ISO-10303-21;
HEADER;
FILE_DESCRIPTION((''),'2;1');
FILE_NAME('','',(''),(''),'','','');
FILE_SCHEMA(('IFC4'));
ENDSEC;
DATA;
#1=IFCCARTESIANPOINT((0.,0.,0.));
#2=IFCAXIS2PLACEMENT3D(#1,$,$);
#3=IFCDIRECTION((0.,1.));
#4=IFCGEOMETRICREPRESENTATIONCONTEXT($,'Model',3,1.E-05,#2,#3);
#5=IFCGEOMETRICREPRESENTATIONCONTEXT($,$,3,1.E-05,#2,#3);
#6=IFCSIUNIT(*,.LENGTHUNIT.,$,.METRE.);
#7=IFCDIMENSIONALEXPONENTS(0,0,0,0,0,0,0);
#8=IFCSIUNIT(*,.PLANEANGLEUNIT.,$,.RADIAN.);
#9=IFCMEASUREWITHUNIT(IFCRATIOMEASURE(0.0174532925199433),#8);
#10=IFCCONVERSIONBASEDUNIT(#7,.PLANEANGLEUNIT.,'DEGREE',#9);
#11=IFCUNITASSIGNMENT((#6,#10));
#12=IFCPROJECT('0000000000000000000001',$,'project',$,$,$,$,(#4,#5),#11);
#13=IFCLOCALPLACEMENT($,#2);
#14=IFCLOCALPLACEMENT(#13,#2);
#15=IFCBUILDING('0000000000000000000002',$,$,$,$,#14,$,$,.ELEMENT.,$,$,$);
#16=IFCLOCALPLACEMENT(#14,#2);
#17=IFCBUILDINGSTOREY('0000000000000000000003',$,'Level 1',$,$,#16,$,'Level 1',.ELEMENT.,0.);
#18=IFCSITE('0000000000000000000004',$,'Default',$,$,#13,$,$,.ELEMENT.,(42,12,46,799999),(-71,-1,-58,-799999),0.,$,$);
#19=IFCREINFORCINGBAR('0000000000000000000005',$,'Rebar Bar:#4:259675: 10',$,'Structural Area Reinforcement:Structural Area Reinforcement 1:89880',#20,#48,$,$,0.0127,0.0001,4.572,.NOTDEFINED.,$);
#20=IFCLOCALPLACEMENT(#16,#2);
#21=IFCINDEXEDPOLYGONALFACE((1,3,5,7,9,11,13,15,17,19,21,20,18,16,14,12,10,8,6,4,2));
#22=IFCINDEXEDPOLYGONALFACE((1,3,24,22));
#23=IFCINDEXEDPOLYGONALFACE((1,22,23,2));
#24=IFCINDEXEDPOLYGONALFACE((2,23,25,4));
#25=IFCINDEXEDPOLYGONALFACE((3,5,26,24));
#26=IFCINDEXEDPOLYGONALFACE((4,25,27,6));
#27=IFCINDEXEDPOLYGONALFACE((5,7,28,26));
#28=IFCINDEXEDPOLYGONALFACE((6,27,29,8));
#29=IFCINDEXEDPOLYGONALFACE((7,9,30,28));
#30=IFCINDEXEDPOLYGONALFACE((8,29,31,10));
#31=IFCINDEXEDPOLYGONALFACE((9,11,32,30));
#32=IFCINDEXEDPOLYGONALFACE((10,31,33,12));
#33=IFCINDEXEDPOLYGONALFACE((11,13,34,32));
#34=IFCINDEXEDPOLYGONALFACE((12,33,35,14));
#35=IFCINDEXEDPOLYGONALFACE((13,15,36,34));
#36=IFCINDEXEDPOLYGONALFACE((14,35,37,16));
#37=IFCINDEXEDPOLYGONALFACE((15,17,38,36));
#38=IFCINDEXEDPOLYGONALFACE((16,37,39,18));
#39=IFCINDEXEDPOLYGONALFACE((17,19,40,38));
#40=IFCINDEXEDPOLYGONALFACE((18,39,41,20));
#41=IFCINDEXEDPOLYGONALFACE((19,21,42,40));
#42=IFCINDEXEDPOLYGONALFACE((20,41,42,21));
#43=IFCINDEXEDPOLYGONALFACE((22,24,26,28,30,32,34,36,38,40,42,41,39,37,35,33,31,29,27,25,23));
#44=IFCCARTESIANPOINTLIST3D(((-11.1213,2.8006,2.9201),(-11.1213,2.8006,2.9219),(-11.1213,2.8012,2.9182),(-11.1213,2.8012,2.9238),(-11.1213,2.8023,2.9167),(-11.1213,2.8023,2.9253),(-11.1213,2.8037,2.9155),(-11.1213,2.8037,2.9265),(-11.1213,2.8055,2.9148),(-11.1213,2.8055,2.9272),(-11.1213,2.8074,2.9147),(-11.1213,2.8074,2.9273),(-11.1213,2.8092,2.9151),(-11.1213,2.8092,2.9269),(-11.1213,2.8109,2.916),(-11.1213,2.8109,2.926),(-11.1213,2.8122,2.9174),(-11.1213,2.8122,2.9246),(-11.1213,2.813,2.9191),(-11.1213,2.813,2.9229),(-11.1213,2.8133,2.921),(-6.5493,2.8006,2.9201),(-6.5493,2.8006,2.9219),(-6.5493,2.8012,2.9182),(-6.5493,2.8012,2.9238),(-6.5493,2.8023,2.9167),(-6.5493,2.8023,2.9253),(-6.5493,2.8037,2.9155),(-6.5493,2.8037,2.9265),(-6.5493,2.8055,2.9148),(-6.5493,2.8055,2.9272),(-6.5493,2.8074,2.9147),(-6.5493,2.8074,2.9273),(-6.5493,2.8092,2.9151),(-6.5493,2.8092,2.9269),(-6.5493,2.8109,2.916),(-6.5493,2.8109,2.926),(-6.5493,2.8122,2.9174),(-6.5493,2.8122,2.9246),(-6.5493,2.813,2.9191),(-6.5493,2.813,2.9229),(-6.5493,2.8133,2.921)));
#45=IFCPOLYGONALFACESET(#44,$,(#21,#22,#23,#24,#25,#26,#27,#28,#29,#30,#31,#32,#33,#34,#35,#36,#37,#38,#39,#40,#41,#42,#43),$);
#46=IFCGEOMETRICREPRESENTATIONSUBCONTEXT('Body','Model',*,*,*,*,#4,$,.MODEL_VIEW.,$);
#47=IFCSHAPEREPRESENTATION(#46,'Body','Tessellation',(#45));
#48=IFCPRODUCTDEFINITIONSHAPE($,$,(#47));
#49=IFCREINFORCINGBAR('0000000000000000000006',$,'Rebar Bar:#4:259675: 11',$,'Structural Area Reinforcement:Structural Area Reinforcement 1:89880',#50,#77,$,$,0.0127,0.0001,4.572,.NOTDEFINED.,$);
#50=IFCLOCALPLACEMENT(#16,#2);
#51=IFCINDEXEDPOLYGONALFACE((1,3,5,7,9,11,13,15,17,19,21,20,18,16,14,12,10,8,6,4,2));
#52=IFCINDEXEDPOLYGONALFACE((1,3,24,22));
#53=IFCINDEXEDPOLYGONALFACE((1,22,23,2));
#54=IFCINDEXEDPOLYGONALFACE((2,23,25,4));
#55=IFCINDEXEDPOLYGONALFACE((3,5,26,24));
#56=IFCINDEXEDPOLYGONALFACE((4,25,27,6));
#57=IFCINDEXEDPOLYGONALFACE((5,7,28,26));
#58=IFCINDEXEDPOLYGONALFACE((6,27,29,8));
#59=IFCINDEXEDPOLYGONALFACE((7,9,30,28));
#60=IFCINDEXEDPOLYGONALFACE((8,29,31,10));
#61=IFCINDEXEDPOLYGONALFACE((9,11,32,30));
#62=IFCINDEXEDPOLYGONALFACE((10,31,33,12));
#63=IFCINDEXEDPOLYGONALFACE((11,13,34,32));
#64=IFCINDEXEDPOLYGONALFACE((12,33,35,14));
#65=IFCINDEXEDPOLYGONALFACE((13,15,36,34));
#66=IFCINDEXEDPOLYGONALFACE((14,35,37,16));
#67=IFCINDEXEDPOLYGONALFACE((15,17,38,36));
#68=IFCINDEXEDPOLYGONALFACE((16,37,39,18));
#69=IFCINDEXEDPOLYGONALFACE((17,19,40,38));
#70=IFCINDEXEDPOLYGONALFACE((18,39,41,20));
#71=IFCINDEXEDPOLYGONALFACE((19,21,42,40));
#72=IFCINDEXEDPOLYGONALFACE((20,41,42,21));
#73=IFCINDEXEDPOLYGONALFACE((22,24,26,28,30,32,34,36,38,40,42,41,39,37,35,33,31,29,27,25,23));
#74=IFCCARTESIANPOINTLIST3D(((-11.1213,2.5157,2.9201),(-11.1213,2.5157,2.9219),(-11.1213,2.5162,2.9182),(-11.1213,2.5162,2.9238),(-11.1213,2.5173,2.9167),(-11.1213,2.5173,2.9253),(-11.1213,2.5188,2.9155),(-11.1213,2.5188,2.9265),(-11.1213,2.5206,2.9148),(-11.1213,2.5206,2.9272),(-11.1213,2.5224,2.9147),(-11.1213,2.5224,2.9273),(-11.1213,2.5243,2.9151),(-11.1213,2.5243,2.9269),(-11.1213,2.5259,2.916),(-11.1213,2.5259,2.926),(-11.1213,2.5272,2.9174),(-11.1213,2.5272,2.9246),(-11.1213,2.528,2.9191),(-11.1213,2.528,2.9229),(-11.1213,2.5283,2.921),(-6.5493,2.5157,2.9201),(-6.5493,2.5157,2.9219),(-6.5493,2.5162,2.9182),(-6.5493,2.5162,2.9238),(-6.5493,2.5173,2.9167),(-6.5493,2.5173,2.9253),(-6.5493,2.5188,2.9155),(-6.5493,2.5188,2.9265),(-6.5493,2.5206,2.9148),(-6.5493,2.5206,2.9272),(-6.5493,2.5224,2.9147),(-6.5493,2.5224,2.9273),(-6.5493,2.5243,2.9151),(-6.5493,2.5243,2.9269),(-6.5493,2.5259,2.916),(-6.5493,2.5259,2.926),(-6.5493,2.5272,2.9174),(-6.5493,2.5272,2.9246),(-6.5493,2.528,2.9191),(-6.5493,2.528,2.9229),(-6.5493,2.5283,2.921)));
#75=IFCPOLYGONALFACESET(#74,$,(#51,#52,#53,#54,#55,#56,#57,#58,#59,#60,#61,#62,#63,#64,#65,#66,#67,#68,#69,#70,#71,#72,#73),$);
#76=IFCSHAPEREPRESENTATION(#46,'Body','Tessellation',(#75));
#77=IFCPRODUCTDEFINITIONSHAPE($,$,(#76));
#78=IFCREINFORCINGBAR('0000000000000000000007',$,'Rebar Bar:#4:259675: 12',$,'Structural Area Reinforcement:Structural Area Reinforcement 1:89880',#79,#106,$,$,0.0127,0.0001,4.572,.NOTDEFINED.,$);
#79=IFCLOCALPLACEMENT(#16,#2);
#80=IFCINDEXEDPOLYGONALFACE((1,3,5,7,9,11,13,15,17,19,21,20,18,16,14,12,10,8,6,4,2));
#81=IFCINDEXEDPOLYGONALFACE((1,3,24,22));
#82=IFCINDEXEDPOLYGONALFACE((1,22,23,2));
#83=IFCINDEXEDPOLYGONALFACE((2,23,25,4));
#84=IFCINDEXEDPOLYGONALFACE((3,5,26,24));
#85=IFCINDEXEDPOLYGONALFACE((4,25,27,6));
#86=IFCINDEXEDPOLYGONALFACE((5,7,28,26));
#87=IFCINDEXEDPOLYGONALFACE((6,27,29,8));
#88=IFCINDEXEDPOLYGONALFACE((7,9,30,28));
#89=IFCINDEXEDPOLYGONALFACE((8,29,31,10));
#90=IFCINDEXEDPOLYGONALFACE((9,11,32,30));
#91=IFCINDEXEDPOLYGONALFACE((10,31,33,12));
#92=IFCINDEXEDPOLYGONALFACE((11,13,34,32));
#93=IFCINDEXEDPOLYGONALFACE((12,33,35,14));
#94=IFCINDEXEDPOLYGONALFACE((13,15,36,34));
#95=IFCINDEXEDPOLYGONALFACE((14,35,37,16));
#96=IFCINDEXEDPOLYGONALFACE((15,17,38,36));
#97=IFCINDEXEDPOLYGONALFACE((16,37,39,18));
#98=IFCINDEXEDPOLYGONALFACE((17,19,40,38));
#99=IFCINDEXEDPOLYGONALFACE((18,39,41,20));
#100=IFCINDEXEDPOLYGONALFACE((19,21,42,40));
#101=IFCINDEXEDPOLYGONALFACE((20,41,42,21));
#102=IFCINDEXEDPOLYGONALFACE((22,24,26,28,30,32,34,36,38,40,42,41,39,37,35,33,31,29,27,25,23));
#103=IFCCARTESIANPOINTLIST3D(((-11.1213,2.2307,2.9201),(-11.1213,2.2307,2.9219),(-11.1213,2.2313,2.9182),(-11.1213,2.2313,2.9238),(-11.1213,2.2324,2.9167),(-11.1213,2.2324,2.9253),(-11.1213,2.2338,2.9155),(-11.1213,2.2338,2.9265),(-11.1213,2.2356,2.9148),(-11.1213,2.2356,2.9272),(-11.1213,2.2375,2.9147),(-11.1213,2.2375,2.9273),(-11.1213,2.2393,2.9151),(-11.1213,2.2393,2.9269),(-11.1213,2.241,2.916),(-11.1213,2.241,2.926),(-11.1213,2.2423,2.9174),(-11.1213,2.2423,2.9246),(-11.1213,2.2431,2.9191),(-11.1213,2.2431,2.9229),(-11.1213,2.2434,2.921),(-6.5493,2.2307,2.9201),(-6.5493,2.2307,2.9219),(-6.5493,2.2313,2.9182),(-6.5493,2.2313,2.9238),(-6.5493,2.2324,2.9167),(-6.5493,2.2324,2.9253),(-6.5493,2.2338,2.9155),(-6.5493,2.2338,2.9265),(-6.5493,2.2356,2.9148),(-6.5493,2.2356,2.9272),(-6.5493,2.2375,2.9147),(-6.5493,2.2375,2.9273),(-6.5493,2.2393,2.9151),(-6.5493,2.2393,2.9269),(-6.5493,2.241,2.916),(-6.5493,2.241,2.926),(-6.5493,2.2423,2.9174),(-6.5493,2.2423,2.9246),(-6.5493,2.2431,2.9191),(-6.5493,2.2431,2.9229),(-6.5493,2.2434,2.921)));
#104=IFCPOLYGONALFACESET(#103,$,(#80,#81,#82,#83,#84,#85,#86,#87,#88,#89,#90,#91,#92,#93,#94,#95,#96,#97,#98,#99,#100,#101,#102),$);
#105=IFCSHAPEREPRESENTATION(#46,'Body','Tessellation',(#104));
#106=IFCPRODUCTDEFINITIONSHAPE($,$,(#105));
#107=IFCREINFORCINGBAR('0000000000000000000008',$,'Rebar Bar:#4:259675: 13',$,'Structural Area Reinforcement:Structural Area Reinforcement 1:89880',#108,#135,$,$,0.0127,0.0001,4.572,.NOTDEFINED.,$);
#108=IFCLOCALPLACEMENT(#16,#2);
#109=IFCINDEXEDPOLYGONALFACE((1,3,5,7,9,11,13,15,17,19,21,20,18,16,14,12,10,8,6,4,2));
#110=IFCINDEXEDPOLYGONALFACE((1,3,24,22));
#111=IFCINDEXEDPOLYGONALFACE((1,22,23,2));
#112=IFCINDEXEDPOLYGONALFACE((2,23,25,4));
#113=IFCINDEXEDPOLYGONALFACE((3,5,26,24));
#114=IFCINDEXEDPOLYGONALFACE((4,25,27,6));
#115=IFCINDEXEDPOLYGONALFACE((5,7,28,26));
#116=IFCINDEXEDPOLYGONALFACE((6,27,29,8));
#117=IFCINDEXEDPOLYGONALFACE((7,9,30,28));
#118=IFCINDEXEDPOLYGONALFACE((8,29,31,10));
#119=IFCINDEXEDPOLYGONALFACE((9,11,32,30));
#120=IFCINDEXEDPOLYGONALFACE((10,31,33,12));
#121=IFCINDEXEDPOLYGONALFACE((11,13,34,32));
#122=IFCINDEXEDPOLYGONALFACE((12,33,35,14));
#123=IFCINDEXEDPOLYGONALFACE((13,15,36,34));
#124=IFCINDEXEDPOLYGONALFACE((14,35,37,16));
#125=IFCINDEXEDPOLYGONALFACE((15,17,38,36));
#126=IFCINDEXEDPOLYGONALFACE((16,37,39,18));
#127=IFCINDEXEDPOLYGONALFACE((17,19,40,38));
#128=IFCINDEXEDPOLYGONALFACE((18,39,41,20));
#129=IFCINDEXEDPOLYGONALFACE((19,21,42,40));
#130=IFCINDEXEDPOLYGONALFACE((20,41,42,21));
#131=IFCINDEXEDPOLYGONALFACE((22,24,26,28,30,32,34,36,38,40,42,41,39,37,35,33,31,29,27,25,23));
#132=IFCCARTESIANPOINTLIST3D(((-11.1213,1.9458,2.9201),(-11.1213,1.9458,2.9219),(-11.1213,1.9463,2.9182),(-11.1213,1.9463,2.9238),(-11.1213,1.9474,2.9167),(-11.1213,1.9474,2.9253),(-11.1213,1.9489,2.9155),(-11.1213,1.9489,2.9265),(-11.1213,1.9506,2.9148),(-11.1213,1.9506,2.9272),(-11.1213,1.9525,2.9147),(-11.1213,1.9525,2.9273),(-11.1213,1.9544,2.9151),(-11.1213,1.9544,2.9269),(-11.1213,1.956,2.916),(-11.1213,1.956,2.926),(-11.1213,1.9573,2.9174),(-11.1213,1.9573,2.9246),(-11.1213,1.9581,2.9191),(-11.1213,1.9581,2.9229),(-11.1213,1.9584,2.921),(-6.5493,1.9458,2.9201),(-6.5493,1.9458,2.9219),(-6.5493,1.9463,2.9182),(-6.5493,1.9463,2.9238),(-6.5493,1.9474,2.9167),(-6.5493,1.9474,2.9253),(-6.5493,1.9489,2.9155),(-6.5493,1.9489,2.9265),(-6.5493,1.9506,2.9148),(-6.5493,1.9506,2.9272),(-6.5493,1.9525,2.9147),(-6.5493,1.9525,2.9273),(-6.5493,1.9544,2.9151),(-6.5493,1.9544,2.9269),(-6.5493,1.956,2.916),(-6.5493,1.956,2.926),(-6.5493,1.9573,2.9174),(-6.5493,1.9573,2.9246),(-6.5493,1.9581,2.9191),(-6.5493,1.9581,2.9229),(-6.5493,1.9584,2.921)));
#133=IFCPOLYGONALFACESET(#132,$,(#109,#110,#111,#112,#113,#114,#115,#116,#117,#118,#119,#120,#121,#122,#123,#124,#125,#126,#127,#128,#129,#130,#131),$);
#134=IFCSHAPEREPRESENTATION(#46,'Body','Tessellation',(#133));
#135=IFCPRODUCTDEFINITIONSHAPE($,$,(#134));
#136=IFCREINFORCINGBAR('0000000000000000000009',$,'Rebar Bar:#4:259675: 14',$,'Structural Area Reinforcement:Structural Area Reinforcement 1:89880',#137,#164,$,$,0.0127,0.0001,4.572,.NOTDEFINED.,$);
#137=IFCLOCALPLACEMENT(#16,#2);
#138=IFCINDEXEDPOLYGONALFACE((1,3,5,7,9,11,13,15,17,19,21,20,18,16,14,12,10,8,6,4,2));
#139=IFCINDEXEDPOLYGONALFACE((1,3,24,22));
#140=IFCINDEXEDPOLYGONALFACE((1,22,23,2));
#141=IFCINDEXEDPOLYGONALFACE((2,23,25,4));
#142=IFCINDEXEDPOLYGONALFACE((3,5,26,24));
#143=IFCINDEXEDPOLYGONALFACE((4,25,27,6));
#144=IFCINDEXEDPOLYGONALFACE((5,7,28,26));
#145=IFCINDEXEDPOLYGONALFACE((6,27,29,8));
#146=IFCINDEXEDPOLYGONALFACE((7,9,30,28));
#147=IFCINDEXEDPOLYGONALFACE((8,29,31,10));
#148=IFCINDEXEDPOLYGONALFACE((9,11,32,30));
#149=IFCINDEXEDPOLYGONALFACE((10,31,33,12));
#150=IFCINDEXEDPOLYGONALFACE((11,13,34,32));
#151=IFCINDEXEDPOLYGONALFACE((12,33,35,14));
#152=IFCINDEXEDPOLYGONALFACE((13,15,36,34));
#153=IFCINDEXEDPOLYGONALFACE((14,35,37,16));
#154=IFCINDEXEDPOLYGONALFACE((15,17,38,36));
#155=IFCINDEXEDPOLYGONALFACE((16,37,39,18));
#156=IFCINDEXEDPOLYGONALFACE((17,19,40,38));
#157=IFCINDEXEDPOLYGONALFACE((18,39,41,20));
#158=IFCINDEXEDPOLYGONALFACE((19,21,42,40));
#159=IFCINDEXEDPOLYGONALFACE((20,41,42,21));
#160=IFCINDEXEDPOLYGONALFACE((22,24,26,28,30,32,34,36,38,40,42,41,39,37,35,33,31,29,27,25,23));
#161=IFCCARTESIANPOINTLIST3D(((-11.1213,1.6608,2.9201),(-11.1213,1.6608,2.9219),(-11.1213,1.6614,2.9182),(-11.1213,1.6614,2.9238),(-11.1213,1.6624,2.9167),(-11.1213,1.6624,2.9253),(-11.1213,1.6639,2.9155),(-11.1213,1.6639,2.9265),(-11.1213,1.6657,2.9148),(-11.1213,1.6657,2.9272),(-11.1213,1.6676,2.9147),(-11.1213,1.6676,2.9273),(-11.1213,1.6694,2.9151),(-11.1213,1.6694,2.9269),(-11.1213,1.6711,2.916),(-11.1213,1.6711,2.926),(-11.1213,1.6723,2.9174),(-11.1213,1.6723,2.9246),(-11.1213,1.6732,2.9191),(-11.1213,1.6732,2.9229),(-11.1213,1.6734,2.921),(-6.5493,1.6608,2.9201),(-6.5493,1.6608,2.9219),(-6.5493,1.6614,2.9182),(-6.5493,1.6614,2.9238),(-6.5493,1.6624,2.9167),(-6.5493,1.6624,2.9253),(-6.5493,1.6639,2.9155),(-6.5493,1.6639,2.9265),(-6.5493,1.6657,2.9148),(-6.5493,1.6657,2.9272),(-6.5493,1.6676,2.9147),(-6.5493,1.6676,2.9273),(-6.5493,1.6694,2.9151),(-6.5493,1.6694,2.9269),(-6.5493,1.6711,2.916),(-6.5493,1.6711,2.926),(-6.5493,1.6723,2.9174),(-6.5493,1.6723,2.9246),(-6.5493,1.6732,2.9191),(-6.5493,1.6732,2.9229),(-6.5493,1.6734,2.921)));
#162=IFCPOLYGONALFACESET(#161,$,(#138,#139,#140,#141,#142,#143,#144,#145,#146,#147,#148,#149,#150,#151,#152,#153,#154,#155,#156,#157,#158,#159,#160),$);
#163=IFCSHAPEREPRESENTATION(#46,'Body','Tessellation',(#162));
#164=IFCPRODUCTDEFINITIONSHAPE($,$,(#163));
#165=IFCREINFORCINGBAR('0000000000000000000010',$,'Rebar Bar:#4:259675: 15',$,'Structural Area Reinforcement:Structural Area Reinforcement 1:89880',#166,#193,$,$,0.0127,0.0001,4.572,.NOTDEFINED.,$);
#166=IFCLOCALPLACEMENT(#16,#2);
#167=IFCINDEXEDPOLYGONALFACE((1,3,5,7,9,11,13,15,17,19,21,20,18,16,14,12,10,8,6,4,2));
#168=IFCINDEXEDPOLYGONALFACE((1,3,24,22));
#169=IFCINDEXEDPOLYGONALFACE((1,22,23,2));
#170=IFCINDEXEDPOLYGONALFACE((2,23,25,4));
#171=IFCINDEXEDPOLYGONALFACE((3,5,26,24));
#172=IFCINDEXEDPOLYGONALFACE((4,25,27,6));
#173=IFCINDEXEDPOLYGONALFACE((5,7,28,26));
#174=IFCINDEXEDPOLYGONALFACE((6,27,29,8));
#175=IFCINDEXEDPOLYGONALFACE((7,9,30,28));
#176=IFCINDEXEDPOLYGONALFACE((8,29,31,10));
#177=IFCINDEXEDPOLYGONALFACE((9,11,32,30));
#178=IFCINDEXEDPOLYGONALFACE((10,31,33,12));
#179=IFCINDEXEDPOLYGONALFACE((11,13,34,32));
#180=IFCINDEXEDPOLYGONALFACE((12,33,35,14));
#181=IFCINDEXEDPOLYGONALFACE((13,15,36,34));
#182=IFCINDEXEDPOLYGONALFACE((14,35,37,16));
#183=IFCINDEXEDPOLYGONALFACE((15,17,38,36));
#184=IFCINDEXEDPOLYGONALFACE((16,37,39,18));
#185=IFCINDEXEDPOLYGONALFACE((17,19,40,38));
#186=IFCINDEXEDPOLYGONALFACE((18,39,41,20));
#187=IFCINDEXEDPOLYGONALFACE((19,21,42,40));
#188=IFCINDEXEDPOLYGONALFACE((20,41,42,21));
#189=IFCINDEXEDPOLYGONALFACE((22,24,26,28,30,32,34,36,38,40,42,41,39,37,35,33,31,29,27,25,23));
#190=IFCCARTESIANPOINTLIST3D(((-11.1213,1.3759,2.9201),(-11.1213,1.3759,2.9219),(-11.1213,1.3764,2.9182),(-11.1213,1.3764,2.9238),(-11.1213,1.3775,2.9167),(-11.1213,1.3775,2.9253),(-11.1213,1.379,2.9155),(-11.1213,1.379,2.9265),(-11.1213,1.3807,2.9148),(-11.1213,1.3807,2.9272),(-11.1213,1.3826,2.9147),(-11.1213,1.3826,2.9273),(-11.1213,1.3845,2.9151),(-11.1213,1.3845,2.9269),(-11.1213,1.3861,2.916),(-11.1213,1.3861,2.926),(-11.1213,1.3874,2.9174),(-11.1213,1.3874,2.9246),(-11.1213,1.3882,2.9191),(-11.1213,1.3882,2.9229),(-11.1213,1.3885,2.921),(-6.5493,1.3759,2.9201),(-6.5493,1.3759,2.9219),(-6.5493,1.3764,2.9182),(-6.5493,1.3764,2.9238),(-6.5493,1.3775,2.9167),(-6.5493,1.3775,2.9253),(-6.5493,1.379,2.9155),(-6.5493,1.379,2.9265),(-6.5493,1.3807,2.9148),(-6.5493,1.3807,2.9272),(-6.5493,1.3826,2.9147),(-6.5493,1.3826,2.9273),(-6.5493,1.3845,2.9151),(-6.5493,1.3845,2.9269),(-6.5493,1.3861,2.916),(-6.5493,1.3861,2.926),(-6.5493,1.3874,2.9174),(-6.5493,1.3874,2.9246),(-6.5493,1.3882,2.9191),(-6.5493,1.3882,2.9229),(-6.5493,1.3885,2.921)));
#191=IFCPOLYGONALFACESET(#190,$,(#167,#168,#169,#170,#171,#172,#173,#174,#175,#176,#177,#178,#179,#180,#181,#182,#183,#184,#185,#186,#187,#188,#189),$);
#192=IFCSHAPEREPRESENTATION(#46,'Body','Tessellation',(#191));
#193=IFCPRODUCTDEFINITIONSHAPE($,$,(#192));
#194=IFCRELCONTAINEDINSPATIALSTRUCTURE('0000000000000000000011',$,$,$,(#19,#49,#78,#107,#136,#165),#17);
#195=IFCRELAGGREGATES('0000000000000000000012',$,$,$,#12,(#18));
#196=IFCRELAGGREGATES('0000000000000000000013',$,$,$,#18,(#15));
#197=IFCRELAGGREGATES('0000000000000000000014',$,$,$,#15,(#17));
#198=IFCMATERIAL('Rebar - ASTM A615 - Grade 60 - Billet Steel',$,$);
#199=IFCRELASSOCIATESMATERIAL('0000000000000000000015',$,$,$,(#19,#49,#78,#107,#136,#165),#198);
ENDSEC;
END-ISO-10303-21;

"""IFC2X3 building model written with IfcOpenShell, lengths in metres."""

from ifc_helpers import new_model, entity, si_unit, converted_unit, direction, origin, place, context, subcontext, project, spatial, material, element, save


model = new_model("IFC2X3")

# Units and contexts
model_context = context("Model", 3, precision=1e-05, world=origin(), true_north=direction((0.0, 1.0)))
context_of_model = context(None, 3, precision=1e-05, world=origin(), true_north=direction((0.0, 1.0)))
body_context = subcontext(model_context, "Body", "Model", "MODEL_VIEW")
ifc_project = project(units=[si_unit("LENGTHUNIT", "METRE"), converted_unit("PLANEANGLEUNIT", "DEGREE", entity("IfcRatioMeasure", 0.0174532925199433), si_unit("PLANEANGLEUNIT", "RADIAN"), dimensions=[0, 0, 0, 0, 0, 0, 0])], contexts=[model_context, context_of_model])

# Site, building, storey
site_placement = place(None, origin())
site = spatial("IfcSite", under=ifc_project, at=site_placement, Name="Default", CompositionType="ELEMENT", RefLatitude=(42, 12, 46, 799999), RefLongitude=(-71, -1, -58, -799999), RefElevation=0.0)
building_placement = place(site_placement, origin())
building = spatial("IfcBuilding", under=site, at=building_placement, CompositionType="ELEMENT")
storey_placement = place(building_placement, origin())
storey = spatial("IfcBuildingStorey", under=building, at=storey_placement, Name="Level 1", LongName="Level 1", CompositionType="ELEMENT", Elevation=0.0)

# Reinforcing bars
ifc_material_1 = material(Name="Rebar - ASTM A615 - Grade 60 - Billet Steel")
reinforcing_bar_1_placement = place(storey_placement, origin())
element("IfcReinforcingBar", 1, at=reinforcing_bar_1_placement, inside=storey, material=ifc_material_1, Name="Rebar Bar:#4:259675: 10", ObjectType="Structural Area Reinforcement:Structural Area Reinforcement 1:89880", BarLength=4.572, BarRole="NOTDEFINED", CrossSectionArea=0.0001, NominalDiameter=0.0127, context=body_context, shape_type="AdvancedSweptSolid", body=[
    entity("IfcSweptDiskSolid", entity("IfcCompositeCurve", [entity("IfcCompositeCurveSegment", "CONTINUOUS", True, entity("IfcPolyline", [entity("IfcCartesianPoint", [-11.1213, 2.8069, 2.921]), entity("IfcCartesianPoint", [-6.5493, 2.8069, 2.921])]))], False), 0.0063, None, 0.0, 1.0),
])
reinforcing_bar_2_placement = place(storey_placement, origin())
element("IfcReinforcingBar", 2, at=reinforcing_bar_2_placement, inside=storey, material=ifc_material_1, Name="Rebar Bar:#4:259675: 11", ObjectType="Structural Area Reinforcement:Structural Area Reinforcement 1:89880", BarLength=4.572, BarRole="NOTDEFINED", CrossSectionArea=0.0001, NominalDiameter=0.0127, context=body_context, shape_type="AdvancedSweptSolid", body=[
    entity("IfcSweptDiskSolid", entity("IfcCompositeCurve", [entity("IfcCompositeCurveSegment", "CONTINUOUS", True, entity("IfcPolyline", [entity("IfcCartesianPoint", [-11.1213, 2.522, 2.921]), entity("IfcCartesianPoint", [-6.5493, 2.522, 2.921])]))], False), 0.0063, None, 0.0, 1.0),
])
reinforcing_bar_3_placement = place(storey_placement, origin())
element("IfcReinforcingBar", 3, at=reinforcing_bar_3_placement, inside=storey, material=ifc_material_1, Name="Rebar Bar:#4:259675: 12", ObjectType="Structural Area Reinforcement:Structural Area Reinforcement 1:89880", BarLength=4.572, BarRole="NOTDEFINED", CrossSectionArea=0.0001, NominalDiameter=0.0127, context=body_context, shape_type="AdvancedSweptSolid", body=[
    entity("IfcSweptDiskSolid", entity("IfcCompositeCurve", [entity("IfcCompositeCurveSegment", "CONTINUOUS", True, entity("IfcPolyline", [entity("IfcCartesianPoint", [-11.1213, 2.237, 2.921]), entity("IfcCartesianPoint", [-6.5493, 2.237, 2.921])]))], False), 0.0063, None, 0.0, 1.0),
])
reinforcing_bar_4_placement = place(storey_placement, origin())
element("IfcReinforcingBar", 4, at=reinforcing_bar_4_placement, inside=storey, material=ifc_material_1, Name="Rebar Bar:#4:259675: 13", ObjectType="Structural Area Reinforcement:Structural Area Reinforcement 1:89880", BarLength=4.572, BarRole="NOTDEFINED", CrossSectionArea=0.0001, NominalDiameter=0.0127, context=body_context, shape_type="AdvancedSweptSolid", body=[
    entity("IfcSweptDiskSolid", entity("IfcCompositeCurve", [entity("IfcCompositeCurveSegment", "CONTINUOUS", True, entity("IfcPolyline", [entity("IfcCartesianPoint", [-11.1213, 1.9521, 2.921]), entity("IfcCartesianPoint", [-6.5493, 1.9521, 2.921])]))], False), 0.0063, None, 0.0, 1.0),
])
reinforcing_bar_5_placement = place(storey_placement, origin())
element("IfcReinforcingBar", 5, at=reinforcing_bar_5_placement, inside=storey, material=ifc_material_1, Name="Rebar Bar:#4:259675: 14", ObjectType="Structural Area Reinforcement:Structural Area Reinforcement 1:89880", BarLength=4.572, BarRole="NOTDEFINED", CrossSectionArea=0.0001, NominalDiameter=0.0127, context=body_context, shape_type="AdvancedSweptSolid", body=[
    entity("IfcSweptDiskSolid", entity("IfcCompositeCurve", [entity("IfcCompositeCurveSegment", "CONTINUOUS", True, entity("IfcPolyline", [entity("IfcCartesianPoint", [-11.1213, 1.6671, 2.921]), entity("IfcCartesianPoint", [-6.5493, 1.6671, 2.921])]))], False), 0.0063, None, 0.0, 1.0),
])
reinforcing_bar_6_placement = place(storey_placement, origin())
element("IfcReinforcingBar", 6, at=reinforcing_bar_6_placement, inside=storey, material=ifc_material_1, Name="Rebar Bar:#4:259675: 15", ObjectType="Structural Area Reinforcement:Structural Area Reinforcement 1:89880", BarLength=4.572, BarRole="NOTDEFINED", CrossSectionArea=0.0001, NominalDiameter=0.0127, context=body_context, shape_type="AdvancedSweptSolid", body=[
    entity("IfcSweptDiskSolid", entity("IfcCompositeCurve", [entity("IfcCompositeCurveSegment", "CONTINUOUS", True, entity("IfcPolyline", [entity("IfcCartesianPoint", [-11.1213, 1.3821, 2.921]), entity("IfcCartesianPoint", [-6.5493, 1.3821, 2.921])]))], False), 0.0063, None, 0.0, 1.0),
])

save(model, "model.ifc")
